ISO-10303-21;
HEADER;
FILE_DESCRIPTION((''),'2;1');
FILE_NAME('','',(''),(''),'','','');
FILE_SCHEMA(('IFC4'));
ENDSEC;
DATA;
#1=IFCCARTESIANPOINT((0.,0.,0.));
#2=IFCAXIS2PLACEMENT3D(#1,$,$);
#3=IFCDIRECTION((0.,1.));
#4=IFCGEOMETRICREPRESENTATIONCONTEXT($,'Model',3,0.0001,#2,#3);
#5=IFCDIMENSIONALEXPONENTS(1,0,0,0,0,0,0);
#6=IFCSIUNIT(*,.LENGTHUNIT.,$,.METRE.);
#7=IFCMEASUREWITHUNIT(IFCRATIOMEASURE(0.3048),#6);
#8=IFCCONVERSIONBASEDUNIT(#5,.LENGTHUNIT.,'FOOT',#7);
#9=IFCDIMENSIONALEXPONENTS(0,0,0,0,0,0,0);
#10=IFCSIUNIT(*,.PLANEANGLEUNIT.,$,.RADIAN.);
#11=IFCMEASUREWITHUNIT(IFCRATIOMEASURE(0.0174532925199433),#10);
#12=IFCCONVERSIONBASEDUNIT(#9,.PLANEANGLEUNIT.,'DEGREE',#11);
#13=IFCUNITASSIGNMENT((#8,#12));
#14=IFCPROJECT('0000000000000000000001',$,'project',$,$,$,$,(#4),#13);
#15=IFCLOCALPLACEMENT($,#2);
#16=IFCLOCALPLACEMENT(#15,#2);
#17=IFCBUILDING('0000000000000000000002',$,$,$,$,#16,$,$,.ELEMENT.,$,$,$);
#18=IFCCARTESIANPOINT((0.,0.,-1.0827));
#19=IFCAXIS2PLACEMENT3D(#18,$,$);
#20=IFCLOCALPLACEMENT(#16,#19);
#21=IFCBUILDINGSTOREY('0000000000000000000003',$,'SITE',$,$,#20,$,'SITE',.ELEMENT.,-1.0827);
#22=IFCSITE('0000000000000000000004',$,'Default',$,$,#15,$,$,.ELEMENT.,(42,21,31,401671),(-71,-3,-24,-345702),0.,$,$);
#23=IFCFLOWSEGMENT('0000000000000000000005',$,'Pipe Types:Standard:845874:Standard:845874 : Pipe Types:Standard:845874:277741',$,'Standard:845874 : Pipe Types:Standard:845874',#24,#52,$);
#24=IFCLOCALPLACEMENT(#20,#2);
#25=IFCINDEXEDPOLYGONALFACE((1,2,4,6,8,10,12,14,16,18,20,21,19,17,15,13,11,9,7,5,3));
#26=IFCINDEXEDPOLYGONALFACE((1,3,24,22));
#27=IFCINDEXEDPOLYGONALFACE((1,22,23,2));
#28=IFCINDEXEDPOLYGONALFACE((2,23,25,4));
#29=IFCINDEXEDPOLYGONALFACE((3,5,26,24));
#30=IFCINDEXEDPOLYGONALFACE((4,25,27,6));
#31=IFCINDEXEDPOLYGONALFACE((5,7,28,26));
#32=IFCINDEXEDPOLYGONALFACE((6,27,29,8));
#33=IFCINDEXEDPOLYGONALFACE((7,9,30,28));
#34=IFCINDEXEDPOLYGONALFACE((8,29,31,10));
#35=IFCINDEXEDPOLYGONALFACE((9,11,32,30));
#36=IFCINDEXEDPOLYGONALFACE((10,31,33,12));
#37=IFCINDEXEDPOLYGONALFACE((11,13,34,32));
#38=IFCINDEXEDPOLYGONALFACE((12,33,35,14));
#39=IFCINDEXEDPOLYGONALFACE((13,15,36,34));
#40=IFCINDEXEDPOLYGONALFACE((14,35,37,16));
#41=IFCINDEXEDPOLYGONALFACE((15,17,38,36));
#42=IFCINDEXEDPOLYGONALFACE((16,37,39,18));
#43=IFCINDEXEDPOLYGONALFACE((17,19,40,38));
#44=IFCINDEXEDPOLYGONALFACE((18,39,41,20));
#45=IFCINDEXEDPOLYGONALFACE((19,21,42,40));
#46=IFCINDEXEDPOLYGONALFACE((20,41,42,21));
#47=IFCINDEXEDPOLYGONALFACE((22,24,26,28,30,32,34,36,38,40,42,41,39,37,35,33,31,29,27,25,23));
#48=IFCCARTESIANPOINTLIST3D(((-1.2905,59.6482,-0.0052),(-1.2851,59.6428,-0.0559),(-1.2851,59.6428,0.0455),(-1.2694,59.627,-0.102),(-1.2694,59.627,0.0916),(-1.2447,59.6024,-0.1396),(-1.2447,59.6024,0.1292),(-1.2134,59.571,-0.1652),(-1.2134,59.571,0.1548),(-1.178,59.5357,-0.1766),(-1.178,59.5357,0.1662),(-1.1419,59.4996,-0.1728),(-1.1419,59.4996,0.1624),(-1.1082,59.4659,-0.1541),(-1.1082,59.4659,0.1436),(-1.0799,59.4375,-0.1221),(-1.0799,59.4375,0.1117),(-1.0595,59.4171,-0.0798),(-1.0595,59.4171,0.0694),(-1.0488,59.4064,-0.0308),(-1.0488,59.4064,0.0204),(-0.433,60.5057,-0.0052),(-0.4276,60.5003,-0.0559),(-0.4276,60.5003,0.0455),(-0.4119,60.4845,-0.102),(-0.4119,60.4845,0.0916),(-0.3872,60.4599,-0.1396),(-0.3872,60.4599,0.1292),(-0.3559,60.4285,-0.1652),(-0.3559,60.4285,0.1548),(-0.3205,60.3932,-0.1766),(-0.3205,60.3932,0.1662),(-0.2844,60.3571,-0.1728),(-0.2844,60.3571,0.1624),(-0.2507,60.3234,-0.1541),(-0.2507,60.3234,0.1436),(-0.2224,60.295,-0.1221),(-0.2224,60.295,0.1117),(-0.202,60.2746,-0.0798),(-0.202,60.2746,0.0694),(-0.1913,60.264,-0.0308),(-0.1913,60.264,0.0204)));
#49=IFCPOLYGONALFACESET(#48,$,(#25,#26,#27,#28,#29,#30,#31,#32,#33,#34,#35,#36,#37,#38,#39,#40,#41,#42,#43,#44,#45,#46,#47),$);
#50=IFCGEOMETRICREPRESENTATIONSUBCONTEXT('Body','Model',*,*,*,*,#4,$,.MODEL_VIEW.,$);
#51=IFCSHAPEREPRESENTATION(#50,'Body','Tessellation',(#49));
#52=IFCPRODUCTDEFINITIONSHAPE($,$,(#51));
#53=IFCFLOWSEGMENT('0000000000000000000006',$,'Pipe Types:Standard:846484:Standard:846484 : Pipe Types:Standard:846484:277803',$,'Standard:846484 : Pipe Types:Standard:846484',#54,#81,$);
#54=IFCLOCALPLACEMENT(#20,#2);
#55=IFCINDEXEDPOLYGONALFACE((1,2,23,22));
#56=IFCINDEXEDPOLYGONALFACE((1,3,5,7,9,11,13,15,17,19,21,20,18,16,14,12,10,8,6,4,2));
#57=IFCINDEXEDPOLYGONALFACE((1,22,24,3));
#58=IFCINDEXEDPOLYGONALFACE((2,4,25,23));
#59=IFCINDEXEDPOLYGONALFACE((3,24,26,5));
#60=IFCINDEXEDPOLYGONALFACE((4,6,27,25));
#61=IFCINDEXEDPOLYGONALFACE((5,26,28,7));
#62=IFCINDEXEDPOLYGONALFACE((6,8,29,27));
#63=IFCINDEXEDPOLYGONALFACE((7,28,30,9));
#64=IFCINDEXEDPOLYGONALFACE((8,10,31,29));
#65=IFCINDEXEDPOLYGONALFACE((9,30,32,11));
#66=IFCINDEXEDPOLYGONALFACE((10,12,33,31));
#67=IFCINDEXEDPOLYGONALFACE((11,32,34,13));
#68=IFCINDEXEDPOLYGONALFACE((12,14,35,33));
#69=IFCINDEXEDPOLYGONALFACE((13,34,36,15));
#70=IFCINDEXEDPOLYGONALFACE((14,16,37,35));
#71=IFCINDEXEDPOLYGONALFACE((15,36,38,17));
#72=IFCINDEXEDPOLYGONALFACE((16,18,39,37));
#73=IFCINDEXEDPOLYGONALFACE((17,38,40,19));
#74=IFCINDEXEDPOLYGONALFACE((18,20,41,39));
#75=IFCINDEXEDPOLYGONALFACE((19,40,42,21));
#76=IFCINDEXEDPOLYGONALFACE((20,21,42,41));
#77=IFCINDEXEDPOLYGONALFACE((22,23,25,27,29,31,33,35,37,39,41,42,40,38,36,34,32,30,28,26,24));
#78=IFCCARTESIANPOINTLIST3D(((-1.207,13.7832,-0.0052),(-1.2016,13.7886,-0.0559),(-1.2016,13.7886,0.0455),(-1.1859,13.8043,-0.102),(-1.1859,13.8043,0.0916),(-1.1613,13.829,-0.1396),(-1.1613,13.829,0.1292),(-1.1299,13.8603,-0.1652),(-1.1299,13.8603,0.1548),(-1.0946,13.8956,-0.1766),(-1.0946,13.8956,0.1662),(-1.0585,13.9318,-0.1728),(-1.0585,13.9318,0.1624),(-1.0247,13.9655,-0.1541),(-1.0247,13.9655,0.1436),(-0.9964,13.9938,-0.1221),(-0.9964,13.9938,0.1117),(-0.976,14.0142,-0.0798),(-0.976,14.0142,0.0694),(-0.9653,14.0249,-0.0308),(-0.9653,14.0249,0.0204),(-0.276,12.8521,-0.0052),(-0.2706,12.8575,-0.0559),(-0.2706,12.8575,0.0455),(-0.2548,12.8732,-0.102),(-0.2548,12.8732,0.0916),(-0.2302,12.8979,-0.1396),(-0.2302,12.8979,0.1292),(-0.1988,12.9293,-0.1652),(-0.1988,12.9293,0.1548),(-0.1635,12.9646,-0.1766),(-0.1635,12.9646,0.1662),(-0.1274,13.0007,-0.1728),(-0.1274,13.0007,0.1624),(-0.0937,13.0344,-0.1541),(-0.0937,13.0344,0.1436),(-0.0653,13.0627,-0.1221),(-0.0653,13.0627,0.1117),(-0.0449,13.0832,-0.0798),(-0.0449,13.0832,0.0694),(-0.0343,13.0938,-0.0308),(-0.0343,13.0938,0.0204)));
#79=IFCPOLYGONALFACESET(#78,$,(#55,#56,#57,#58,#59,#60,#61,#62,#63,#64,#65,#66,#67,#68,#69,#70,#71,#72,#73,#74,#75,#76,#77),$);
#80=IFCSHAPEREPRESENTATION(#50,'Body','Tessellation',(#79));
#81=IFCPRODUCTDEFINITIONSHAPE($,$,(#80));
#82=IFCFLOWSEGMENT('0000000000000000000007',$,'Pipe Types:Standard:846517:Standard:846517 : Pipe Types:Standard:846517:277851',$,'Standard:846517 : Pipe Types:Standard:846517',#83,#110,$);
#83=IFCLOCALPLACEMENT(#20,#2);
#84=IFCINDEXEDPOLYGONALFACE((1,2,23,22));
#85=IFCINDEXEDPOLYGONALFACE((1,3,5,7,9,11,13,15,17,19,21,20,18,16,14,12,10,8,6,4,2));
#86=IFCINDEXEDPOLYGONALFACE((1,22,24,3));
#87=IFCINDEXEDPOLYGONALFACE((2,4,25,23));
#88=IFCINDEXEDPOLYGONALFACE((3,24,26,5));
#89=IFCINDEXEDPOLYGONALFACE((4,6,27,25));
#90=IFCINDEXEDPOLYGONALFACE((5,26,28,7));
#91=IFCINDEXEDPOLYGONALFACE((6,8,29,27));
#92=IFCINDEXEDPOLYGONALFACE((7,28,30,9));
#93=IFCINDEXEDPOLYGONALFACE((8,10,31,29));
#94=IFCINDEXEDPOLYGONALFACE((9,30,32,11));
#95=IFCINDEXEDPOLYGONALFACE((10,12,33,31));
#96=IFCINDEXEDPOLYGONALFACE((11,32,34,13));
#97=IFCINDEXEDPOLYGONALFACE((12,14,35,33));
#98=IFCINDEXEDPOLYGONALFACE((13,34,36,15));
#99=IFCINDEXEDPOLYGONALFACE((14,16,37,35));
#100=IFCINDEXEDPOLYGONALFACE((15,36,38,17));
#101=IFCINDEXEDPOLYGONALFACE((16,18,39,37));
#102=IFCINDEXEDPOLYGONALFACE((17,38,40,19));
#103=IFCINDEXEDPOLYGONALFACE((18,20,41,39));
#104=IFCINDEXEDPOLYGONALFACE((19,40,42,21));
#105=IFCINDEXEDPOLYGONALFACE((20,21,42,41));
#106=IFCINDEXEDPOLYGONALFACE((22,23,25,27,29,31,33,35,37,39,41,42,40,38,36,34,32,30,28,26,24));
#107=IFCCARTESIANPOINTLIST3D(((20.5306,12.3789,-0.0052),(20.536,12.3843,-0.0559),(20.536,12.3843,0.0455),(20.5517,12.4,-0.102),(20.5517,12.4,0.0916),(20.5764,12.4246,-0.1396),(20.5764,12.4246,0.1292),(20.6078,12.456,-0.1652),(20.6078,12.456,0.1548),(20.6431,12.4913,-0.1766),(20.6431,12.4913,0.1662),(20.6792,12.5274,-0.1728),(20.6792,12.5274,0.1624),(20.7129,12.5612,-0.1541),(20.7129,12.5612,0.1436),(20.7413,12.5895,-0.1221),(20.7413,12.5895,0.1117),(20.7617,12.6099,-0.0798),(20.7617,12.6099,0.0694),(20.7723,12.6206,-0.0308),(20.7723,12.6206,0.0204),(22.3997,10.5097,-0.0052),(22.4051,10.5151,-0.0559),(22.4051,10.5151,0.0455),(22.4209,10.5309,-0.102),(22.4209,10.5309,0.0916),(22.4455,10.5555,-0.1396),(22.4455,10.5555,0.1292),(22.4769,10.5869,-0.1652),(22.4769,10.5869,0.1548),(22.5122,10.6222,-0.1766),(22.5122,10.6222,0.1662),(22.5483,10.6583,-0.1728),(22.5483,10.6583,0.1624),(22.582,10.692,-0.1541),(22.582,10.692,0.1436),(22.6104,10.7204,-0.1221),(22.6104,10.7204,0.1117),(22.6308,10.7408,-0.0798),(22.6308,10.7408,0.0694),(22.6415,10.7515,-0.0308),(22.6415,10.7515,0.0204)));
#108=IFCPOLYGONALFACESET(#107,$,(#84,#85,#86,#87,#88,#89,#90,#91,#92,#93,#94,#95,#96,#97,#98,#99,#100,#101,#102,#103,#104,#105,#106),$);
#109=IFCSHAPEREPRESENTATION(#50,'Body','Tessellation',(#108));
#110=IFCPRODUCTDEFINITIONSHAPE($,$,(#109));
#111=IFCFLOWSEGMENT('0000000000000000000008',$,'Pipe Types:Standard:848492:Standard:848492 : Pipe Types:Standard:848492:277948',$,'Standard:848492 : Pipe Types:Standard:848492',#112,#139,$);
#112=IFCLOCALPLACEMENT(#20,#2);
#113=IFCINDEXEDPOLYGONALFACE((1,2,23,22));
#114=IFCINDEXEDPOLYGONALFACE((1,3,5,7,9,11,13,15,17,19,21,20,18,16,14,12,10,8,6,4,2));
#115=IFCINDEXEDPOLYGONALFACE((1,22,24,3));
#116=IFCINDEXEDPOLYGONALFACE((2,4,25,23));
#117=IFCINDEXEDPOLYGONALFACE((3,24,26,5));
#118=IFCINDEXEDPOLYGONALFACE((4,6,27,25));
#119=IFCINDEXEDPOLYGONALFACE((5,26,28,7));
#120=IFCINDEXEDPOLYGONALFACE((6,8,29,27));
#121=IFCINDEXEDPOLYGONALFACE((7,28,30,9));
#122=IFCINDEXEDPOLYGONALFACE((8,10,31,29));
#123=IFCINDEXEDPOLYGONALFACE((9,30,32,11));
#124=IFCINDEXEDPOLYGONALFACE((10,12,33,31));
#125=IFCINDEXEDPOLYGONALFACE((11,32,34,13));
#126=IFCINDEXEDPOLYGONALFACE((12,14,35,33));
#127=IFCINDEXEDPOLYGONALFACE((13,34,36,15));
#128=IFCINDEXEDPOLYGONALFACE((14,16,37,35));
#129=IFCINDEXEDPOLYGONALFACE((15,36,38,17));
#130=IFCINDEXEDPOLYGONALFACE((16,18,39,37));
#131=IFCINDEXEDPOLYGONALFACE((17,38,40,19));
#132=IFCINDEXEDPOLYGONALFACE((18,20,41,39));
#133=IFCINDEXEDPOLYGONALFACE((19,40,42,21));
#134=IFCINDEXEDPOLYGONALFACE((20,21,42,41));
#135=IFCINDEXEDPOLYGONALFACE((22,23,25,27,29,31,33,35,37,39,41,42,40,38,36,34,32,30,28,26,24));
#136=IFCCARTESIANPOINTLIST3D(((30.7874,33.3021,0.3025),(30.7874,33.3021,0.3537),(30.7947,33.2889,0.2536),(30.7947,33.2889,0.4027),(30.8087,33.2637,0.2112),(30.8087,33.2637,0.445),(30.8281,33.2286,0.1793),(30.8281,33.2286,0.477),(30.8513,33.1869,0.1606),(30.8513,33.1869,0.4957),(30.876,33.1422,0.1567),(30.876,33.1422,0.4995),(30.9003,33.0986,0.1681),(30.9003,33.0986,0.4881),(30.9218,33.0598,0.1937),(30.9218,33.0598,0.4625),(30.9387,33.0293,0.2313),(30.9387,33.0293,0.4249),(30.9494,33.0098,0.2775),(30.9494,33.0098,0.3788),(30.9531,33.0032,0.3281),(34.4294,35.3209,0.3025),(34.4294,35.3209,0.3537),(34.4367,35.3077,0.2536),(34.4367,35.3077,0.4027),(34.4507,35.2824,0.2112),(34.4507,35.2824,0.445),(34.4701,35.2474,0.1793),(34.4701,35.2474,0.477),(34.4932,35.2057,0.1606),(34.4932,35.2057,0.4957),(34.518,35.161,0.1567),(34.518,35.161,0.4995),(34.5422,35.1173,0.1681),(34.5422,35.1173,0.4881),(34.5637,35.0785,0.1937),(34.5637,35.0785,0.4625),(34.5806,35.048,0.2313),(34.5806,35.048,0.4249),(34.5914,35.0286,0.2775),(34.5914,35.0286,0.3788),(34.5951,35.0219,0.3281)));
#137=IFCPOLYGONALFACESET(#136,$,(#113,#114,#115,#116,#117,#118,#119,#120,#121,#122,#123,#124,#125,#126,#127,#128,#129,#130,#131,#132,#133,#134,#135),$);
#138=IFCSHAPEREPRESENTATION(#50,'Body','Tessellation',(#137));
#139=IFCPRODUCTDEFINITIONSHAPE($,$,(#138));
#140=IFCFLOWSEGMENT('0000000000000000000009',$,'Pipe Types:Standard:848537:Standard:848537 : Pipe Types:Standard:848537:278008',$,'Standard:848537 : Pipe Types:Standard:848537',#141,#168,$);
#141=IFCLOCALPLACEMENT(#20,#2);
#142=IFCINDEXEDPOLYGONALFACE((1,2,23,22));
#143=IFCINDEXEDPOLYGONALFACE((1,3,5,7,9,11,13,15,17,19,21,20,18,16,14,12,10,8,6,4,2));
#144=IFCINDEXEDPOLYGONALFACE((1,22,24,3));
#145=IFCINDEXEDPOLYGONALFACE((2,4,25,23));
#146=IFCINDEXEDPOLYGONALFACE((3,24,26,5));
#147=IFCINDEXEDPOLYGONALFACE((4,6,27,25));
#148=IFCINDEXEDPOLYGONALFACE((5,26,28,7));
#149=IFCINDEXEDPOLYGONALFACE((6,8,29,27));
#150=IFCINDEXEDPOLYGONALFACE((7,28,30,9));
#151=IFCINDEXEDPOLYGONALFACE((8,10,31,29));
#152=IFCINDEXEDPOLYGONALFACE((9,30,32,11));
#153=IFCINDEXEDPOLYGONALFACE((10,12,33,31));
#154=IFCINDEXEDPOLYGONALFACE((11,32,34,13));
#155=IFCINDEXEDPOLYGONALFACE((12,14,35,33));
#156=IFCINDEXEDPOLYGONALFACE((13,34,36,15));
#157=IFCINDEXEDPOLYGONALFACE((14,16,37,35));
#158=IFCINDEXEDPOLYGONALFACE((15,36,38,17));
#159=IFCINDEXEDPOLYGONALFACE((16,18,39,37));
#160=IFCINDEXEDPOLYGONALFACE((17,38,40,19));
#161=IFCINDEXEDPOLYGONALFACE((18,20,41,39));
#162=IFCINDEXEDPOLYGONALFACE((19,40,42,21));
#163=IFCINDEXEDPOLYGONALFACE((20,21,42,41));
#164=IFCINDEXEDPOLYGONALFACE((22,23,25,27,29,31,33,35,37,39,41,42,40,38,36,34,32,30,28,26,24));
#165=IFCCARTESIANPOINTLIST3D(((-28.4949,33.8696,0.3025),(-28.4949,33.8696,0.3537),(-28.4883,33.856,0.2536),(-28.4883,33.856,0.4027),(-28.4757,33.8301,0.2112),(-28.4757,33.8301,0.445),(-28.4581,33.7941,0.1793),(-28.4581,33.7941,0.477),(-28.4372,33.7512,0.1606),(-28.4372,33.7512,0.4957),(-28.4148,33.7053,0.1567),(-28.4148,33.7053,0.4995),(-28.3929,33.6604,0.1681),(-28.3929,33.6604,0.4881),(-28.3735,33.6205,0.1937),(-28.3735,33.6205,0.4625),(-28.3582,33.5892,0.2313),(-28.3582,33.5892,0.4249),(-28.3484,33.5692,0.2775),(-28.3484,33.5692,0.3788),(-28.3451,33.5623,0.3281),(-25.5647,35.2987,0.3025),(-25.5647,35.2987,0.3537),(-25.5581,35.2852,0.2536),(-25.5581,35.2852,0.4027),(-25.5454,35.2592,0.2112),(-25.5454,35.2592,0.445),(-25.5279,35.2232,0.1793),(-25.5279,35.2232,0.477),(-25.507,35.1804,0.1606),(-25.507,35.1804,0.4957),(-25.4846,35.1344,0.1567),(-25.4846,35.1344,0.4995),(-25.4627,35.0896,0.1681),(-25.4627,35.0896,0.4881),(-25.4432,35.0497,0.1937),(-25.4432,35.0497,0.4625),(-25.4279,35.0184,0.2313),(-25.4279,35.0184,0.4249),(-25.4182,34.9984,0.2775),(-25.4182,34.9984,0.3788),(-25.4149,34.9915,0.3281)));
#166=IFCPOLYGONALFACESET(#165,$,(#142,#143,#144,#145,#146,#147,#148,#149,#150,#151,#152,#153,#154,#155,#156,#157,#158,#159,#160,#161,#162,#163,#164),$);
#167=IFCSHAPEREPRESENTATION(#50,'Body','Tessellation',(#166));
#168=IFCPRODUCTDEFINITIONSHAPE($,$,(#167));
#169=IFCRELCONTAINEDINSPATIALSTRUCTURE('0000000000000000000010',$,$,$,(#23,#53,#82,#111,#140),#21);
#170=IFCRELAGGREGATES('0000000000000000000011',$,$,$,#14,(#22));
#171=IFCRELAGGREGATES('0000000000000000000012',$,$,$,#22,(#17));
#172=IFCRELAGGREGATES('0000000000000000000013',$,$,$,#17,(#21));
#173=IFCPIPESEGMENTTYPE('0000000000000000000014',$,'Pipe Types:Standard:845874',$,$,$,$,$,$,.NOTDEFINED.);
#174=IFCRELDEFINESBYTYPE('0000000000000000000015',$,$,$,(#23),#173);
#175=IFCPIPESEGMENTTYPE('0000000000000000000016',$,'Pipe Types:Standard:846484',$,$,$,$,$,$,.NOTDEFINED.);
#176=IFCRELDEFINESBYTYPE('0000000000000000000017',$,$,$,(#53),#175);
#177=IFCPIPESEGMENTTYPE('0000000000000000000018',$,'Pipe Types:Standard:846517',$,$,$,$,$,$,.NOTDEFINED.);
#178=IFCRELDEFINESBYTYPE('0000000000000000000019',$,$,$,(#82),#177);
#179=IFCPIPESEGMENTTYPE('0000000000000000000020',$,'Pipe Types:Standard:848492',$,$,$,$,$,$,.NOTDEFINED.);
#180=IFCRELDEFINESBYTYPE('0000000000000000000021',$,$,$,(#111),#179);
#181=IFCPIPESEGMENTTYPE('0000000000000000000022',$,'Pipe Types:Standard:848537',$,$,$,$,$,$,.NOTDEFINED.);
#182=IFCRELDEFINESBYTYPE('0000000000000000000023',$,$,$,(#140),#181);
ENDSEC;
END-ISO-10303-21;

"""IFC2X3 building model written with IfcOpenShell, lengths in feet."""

from ifc_helpers import new_model, entity, si_unit, converted_unit, direction, frame, frame_2d, origin, place, context, subcontext, project, spatial, circle, extrude, source, transform, mapped, type_object, type_shapes, element, save


model = new_model("IFC2X3")

# Units and contexts
model_context = context("Model", 3, precision=0.0001, world=origin(), true_north=direction((0.0, 1.0)))
body_context = subcontext(model_context, "Body", "Model", "MODEL_VIEW")
ifc_project = project(units=[converted_unit("LENGTHUNIT", "FOOT", entity("IfcRatioMeasure", 0.3048), si_unit("LENGTHUNIT", "METRE"), dimensions=[1, 0, 0, 0, 0, 0, 0]), converted_unit("PLANEANGLEUNIT", "DEGREE", entity("IfcRatioMeasure", 0.0174532925199433), si_unit("PLANEANGLEUNIT", "RADIAN"), dimensions=[0, 0, 0, 0, 0, 0, 0])], contexts=[model_context])

# Site, building, storey
site_placement = place(None, origin())
site = spatial("IfcSite", under=ifc_project, at=site_placement, Name="Default", CompositionType="ELEMENT", RefLatitude=(42, 21, 31, 401671), RefLongitude=(-71, -3, -24, -345702), RefElevation=0.0)
building_placement = place(site_placement, origin())
building = spatial("IfcBuilding", under=site, at=building_placement, CompositionType="ELEMENT")
storey_placement = place(building_placement, frame((0.0, 0.0, -1.0827)))
storey = spatial("IfcBuildingStorey", under=building, at=storey_placement, Name="SITE", LongName="SITE", CompositionType="ELEMENT", Elevation=-1.0827)

# Flow segments
pipe_segment_type_1 = type_object("IfcPipeSegmentType", Name="Pipe Types:Standard:845874", PredefinedType="NOTDEFINED")
shared_shape_1 = source(origin(), body_context, "Body", "SweptSolid", [
    extrude(circle(Radius=0.1719, at=frame_2d((0.0, 0.0), x_axis=(1.0, 0.0))), frame((-1.169, 59.5266, -1.0879), z_axis=(0.707107, 0.707107, 0.0), x_axis=(-0.707107, 0.707107, 0.0)), (0.0, 0.0, 1.0), 1.2127),
])
type_shapes(pipe_segment_type_1, [shared_shape_1])
flow_segment_1_placement = place(storey_placement, frame((0.0, 0.0, 1.0827)))
element("IfcFlowSegment", 1, at=flow_segment_1_placement, inside=storey, type_object=pipe_segment_type_1, Name="Pipe Types:Standard:845874:Standard:845874 : Pipe Types:Standard:845874:277741", ObjectType="Standard:845874 : Pipe Types:Standard:845874", context=body_context, shape_type="MappedRepresentation", body=[
    mapped(shared_shape_1, transform((0.0, 0.0, 0.0), scale=1.0)),
])
pipe_segment_type_2 = type_object("IfcPipeSegmentType", Name="Pipe Types:Standard:846484", PredefinedType="NOTDEFINED")
shared_shape_2 = source(origin(), body_context, "Body", "SweptSolid", [
    extrude(circle(Radius=0.1719, at=frame_2d((0.0, 0.0), x_axis=(1.0, 0.0))), frame((-1.0855, 13.9047, -1.0879), z_axis=(0.707107, -0.707107, 0.0), x_axis=(-0.707107, -0.707107, 0.0)), (0.0, 0.0, 1.0), 1.3167),
])
type_shapes(pipe_segment_type_2, [shared_shape_2])
flow_segment_2_placement = place(storey_placement, frame((0.0, 0.0, 1.0827)))
element("IfcFlowSegment", 2, at=flow_segment_2_placement, inside=storey, type_object=pipe_segment_type_2, Name="Pipe Types:Standard:846484:Standard:846484 : Pipe Types:Standard:846484:277803", ObjectType="Standard:846484 : Pipe Types:Standard:846484", context=body_context, shape_type="MappedRepresentation", body=[
    mapped(shared_shape_2, transform((0.0, 0.0, 0.0), scale=1.0)),
])
pipe_segment_type_3 = type_object("IfcPipeSegmentType", Name="Pipe Types:Standard:846517", PredefinedType="NOTDEFINED")
shared_shape_3 = source(origin(), body_context, "Body", "SweptSolid", [
    extrude(circle(Radius=0.1719, at=frame_2d((0.0, 0.0), x_axis=(1.0, 0.0))), frame((20.6522, 12.5004, -1.0879), z_axis=(0.707107, -0.707107, 0.0), x_axis=(-0.707107, -0.707107, 0.0)), (0.0, 0.0, 1.0), 2.6433),
])
type_shapes(pipe_segment_type_3, [shared_shape_3])
flow_segment_3_placement = place(storey_placement, frame((0.0, 0.0, 1.0827)))
element("IfcFlowSegment", 3, at=flow_segment_3_placement, inside=storey, type_object=pipe_segment_type_3, Name="Pipe Types:Standard:846517:Standard:846517 : Pipe Types:Standard:846517:277851", ObjectType="Standard:846517 : Pipe Types:Standard:846517", context=body_context, shape_type="MappedRepresentation", body=[
    mapped(shared_shape_3, transform((0.0, 0.0, 0.0), scale=1.0)),
])
pipe_segment_type_4 = type_object("IfcPipeSegmentType", Name="Pipe Types:Standard:848492", PredefinedType="NOTDEFINED")
shared_shape_4 = source(origin(), body_context, "Body", "SweptSolid", [
    extrude(circle(Radius=0.1719, at=frame_2d((0.0, 0.0), x_axis=(1.0, 0.0))), frame((30.8698, 33.1535, -0.7546), z_axis=(0.87462, 0.48481, 0.0), x_axis=(0.48481, -0.87462, 0.0)), (0.0, 0.0, 1.0), 4.164),
])
type_shapes(pipe_segment_type_4, [shared_shape_4])
flow_segment_4_placement = place(storey_placement, frame((0.0, 0.0, 1.0827)))
element("IfcFlowSegment", 4, at=flow_segment_4_placement, inside=storey, type_object=pipe_segment_type_4, Name="Pipe Types:Standard:848492:Standard:848492 : Pipe Types:Standard:848492:277948", ObjectType="Standard:848492 : Pipe Types:Standard:848492", context=body_context, shape_type="MappedRepresentation", body=[
    mapped(shared_shape_4, transform((0.0, 0.0, 0.0), scale=1.0)),
])
pipe_segment_type_5 = type_object("IfcPipeSegmentType", Name="Pipe Types:Standard:848537", PredefinedType="NOTDEFINED")
shared_shape_5 = source(origin(), body_context, "Body", "SweptSolid", [
    extrude(circle(Radius=0.1719, at=frame_2d((0.0, 0.0), x_axis=(1.0, 0.0))), frame((-28.4204, 33.7168, -0.7546), z_axis=(0.898794, 0.438371, 0.0), x_axis=(0.438371, -0.898794, 0.0)), (0.0, 0.0, 1.0), 3.2602),
])
type_shapes(pipe_segment_type_5, [shared_shape_5])
flow_segment_5_placement = place(storey_placement, frame((0.0, 0.0, 1.0827)))
element("IfcFlowSegment", 5, at=flow_segment_5_placement, inside=storey, type_object=pipe_segment_type_5, Name="Pipe Types:Standard:848537:Standard:848537 : Pipe Types:Standard:848537:278008", ObjectType="Standard:848537 : Pipe Types:Standard:848537", context=body_context, shape_type="MappedRepresentation", body=[
    mapped(shared_shape_5, transform((0.0, 0.0, 0.0), scale=1.0)),
])

save(model, "model.ifc")
